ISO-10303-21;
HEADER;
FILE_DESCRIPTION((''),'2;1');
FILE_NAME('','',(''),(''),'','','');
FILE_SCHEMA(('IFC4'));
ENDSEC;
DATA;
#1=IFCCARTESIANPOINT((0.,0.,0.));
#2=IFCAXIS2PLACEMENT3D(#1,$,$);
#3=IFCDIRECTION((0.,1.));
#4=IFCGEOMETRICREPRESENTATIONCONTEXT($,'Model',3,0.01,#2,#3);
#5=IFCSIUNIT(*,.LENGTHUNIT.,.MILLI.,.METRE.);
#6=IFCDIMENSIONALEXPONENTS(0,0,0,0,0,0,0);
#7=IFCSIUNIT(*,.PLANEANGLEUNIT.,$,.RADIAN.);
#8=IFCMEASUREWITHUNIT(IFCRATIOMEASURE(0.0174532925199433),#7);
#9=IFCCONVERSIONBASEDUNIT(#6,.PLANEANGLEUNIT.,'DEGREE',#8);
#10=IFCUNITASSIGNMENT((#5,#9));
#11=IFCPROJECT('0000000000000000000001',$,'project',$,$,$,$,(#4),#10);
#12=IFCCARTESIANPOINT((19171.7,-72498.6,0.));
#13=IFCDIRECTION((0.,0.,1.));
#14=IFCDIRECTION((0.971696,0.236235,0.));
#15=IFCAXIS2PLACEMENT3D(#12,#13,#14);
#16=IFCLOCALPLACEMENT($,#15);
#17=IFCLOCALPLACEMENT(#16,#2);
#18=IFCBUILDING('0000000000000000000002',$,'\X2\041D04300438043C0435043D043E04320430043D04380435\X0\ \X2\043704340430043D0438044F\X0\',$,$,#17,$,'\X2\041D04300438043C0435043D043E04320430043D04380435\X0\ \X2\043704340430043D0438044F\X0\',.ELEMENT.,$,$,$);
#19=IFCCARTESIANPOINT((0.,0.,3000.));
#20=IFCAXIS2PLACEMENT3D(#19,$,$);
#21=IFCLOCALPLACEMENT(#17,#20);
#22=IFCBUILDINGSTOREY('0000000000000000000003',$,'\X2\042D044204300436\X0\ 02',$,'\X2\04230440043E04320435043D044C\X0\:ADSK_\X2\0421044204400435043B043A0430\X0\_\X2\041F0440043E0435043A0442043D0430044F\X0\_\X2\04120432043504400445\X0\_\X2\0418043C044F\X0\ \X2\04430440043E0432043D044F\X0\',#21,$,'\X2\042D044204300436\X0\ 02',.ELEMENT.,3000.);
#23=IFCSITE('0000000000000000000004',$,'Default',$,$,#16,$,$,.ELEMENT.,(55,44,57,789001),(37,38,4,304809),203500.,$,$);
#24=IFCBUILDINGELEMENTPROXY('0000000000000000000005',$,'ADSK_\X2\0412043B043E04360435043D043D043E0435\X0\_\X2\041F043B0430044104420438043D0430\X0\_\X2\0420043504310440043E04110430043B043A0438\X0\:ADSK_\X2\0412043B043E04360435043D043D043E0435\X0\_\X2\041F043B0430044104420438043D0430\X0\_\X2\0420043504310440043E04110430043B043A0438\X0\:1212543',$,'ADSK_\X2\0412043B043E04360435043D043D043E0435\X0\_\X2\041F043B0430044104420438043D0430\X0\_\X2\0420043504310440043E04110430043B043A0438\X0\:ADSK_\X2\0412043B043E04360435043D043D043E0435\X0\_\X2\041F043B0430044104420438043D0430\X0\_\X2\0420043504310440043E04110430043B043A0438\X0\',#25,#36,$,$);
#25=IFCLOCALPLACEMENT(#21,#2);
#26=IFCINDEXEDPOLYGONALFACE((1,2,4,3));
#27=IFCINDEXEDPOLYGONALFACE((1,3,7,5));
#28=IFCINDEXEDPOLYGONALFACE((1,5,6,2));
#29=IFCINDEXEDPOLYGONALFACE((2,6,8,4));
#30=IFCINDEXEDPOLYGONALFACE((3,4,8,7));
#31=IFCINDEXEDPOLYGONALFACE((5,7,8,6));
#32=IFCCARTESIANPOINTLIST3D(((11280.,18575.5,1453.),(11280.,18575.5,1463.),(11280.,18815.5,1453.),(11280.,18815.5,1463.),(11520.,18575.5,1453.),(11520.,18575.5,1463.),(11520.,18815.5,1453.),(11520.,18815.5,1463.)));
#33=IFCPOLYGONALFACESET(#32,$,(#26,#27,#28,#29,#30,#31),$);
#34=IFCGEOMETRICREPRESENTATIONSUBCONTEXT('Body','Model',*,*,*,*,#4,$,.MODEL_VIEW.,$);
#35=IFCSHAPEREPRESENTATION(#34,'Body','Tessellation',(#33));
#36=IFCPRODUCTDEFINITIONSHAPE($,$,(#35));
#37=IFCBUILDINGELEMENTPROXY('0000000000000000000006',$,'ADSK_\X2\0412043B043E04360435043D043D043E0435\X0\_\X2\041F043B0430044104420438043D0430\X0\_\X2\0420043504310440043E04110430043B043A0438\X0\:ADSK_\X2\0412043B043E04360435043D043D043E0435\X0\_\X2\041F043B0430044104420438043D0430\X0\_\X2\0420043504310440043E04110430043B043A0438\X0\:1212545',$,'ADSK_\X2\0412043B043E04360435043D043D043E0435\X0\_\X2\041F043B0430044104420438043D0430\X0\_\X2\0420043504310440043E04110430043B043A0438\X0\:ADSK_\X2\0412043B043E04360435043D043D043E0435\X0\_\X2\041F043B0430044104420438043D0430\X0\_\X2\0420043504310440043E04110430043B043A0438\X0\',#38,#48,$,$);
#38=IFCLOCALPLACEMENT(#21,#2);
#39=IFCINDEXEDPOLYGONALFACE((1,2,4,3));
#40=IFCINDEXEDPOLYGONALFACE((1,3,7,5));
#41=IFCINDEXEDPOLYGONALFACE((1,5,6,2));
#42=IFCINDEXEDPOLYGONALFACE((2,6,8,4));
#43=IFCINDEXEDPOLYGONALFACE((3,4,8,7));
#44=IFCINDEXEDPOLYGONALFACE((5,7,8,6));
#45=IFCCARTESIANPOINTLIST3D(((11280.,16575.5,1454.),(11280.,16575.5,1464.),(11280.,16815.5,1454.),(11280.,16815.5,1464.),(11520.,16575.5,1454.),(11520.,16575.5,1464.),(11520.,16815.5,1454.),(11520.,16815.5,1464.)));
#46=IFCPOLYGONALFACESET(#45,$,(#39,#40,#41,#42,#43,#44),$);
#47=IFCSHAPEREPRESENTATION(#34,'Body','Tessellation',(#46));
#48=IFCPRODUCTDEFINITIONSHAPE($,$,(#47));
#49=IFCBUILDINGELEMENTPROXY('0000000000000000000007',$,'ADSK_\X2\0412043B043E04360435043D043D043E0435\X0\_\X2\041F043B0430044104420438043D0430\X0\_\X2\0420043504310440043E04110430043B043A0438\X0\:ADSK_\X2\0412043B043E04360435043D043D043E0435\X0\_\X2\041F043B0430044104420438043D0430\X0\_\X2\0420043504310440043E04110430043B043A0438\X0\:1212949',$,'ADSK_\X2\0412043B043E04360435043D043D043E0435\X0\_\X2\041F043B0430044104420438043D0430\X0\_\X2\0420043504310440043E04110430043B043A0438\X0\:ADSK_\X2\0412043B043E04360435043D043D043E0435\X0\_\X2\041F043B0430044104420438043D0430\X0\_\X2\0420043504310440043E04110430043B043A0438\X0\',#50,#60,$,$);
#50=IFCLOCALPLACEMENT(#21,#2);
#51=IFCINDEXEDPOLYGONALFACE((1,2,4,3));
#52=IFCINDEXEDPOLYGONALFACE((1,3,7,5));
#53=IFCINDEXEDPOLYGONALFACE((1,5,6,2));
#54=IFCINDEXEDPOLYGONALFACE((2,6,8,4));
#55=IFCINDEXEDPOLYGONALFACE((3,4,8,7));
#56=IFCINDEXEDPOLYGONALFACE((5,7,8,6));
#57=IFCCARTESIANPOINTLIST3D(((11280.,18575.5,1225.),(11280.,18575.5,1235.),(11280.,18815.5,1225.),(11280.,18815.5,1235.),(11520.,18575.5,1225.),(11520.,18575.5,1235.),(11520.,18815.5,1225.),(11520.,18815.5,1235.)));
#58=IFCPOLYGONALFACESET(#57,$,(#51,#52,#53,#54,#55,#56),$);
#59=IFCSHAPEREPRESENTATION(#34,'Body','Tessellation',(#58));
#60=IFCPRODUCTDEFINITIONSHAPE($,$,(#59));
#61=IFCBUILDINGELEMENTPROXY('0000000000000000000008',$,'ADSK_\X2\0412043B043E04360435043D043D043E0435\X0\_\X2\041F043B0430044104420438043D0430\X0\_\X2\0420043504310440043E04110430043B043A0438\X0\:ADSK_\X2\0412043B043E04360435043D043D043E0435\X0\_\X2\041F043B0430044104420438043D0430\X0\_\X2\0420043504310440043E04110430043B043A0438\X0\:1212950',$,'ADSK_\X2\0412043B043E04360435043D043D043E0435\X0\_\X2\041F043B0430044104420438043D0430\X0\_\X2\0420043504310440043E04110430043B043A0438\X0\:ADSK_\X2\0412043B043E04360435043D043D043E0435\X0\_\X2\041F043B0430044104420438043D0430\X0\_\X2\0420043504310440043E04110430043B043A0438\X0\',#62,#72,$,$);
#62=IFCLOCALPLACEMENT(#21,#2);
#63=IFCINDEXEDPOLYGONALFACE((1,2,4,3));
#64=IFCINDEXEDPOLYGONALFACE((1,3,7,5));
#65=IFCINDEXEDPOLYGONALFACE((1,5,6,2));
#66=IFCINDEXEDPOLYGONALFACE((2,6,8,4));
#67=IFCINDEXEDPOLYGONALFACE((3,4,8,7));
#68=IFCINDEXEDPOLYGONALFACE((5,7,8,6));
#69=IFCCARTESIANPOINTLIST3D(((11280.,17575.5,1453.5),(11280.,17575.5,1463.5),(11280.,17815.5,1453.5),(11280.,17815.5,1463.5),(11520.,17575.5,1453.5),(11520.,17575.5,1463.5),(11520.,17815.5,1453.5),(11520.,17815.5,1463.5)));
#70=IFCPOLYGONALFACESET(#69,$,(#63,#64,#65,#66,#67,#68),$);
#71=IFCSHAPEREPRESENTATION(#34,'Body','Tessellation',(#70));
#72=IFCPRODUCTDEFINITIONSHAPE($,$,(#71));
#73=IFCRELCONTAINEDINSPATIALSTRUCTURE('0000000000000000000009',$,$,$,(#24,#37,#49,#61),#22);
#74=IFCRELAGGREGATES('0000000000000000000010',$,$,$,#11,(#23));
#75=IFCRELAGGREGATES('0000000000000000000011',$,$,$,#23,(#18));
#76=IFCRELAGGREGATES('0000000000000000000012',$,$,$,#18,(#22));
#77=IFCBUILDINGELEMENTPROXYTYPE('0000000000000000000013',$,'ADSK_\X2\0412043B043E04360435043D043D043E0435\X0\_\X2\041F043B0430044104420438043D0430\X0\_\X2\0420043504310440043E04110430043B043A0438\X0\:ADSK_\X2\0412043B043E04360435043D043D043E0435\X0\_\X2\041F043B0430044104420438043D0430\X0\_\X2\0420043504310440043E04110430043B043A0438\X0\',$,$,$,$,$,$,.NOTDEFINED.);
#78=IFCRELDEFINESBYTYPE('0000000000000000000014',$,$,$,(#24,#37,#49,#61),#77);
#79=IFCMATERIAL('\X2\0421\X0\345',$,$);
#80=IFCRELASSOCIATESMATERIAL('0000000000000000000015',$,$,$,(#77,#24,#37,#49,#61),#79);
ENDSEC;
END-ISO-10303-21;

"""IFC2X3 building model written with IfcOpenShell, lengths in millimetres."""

from ifc_helpers import new_model, entity, si_unit, converted_unit, direction, frame, origin, origin_2d_with_axis, place, context, subcontext, project, spatial, rectangle, extrude, source, transform, mapped, material, type_object, type_shapes, element, save


model = new_model("IFC2X3")

# Units and contexts
model_context = context("Model", 3, precision=0.01, world=origin(), true_north=direction((0.0, 1.0)))
body_context = subcontext(model_context, "Body", "Model", "MODEL_VIEW")
ifc_project = project(units=[si_unit("LENGTHUNIT", "METRE", prefix="MILLI"), converted_unit("PLANEANGLEUNIT", "DEGREE", entity("IfcRatioMeasure", 0.0174532925199433), si_unit("PLANEANGLEUNIT", "RADIAN"), dimensions=[0, 0, 0, 0, 0, 0, 0])], contexts=[model_context])

# Site, building, storey
site_placement = place(None, frame((19171.7, -72498.6, 0.0), z_axis=(0.0, 0.0, 1.0), x_axis=(0.971696, 0.236235, 0.0)))
site = spatial("IfcSite", under=ifc_project, at=site_placement, Name="Default", CompositionType="ELEMENT", RefLatitude=(55, 44, 57, 789001), RefLongitude=(37, 38, 4, 304809), RefElevation=203500.0)
building_placement = place(site_placement, origin())
building = spatial("IfcBuilding", under=site, at=building_placement, Name="Наименование здания", LongName="Наименование здания", CompositionType="ELEMENT")
storey_placement = place(building_placement, frame((0.0, 0.0, 3000.0)))
storey = spatial("IfcBuildingStorey", under=building, at=storey_placement, Name="Этаж 02", ObjectType="Уровень:ADSK_Стрелка_Проектная_Вверх_Имя уровня", LongName="Этаж 02", CompositionType="ELEMENT", Elevation=3000.0)

# Building element proxies
ifc_material_1 = material(Name="С345")
building_element_proxy_type = type_object("IfcBuildingElementProxyType", Name="ADSK_Вложенное_Пластина_РеброБалки:ADSK_Вложенное_Пластина_РеброБалки", PredefinedType="NOTDEFINED", material=ifc_material_1)
shared_shape = source(origin(), body_context, "Body", "SweptSolid", [
    extrude(rectangle(XDim=10.0, YDim=240.0, at=origin_2d_with_axis()), frame((0.0, 0.0, -120.0), z_axis=(0.0, 0.0, 1.0), x_axis=(0.0, 1.0, 0.0)), (0.0, 0.0, 1.0), 240.0),
])
type_shapes(building_element_proxy_type, [shared_shape])
for number, where, z_axis, x_axis, name in (
    (1, (11400.0, 18695.5, 1458.0), (0.0, 1.0, 0.0), (1.0, 0.0, 0.0), "ADSK_Вложенное_Пластина_РеброБалки:ADSK_Вложенное_Пластина_РеброБалки:1212543"),
    (2, (11400.0, 16695.5, 1459.0), (0.0, 1.0, 0.0), (1.0, 0.0, 0.0), "ADSK_Вложенное_Пластина_РеброБалки:ADSK_Вложенное_Пластина_РеброБалки:1212545"),
    (3, (11400.0, 18695.5, 1230.0), (0.0, 1.0, 0.0), (1.0, 0.0, 0.0), "ADSK_Вложенное_Пластина_РеброБалки:ADSK_Вложенное_Пластина_РеброБалки:1212949"),
    (4, (11400.0, 17695.5, 1458.5), (0.0, 1.0, 0.0), (1.0, 0.0, 0.0), "ADSK_Вложенное_Пластина_РеброБалки:ADSK_Вложенное_Пластина_РеброБалки:1212950"),
):
    element("IfcBuildingElementProxy", number, at=place(storey_placement, frame(where, z_axis=z_axis, x_axis=x_axis)), inside=storey, type_object=building_element_proxy_type, material=ifc_material_1, Name=name, ObjectType="ADSK_Вложенное_Пластина_РеброБалки:ADSK_Вложенное_Пластина_РеброБалки", context=body_context, shape_type="MappedRepresentation", body=[
        mapped(shared_shape, transform((0.0, 0.0, 0.0), scale=1.0)),
    ])

save(model, "model.ifc")
